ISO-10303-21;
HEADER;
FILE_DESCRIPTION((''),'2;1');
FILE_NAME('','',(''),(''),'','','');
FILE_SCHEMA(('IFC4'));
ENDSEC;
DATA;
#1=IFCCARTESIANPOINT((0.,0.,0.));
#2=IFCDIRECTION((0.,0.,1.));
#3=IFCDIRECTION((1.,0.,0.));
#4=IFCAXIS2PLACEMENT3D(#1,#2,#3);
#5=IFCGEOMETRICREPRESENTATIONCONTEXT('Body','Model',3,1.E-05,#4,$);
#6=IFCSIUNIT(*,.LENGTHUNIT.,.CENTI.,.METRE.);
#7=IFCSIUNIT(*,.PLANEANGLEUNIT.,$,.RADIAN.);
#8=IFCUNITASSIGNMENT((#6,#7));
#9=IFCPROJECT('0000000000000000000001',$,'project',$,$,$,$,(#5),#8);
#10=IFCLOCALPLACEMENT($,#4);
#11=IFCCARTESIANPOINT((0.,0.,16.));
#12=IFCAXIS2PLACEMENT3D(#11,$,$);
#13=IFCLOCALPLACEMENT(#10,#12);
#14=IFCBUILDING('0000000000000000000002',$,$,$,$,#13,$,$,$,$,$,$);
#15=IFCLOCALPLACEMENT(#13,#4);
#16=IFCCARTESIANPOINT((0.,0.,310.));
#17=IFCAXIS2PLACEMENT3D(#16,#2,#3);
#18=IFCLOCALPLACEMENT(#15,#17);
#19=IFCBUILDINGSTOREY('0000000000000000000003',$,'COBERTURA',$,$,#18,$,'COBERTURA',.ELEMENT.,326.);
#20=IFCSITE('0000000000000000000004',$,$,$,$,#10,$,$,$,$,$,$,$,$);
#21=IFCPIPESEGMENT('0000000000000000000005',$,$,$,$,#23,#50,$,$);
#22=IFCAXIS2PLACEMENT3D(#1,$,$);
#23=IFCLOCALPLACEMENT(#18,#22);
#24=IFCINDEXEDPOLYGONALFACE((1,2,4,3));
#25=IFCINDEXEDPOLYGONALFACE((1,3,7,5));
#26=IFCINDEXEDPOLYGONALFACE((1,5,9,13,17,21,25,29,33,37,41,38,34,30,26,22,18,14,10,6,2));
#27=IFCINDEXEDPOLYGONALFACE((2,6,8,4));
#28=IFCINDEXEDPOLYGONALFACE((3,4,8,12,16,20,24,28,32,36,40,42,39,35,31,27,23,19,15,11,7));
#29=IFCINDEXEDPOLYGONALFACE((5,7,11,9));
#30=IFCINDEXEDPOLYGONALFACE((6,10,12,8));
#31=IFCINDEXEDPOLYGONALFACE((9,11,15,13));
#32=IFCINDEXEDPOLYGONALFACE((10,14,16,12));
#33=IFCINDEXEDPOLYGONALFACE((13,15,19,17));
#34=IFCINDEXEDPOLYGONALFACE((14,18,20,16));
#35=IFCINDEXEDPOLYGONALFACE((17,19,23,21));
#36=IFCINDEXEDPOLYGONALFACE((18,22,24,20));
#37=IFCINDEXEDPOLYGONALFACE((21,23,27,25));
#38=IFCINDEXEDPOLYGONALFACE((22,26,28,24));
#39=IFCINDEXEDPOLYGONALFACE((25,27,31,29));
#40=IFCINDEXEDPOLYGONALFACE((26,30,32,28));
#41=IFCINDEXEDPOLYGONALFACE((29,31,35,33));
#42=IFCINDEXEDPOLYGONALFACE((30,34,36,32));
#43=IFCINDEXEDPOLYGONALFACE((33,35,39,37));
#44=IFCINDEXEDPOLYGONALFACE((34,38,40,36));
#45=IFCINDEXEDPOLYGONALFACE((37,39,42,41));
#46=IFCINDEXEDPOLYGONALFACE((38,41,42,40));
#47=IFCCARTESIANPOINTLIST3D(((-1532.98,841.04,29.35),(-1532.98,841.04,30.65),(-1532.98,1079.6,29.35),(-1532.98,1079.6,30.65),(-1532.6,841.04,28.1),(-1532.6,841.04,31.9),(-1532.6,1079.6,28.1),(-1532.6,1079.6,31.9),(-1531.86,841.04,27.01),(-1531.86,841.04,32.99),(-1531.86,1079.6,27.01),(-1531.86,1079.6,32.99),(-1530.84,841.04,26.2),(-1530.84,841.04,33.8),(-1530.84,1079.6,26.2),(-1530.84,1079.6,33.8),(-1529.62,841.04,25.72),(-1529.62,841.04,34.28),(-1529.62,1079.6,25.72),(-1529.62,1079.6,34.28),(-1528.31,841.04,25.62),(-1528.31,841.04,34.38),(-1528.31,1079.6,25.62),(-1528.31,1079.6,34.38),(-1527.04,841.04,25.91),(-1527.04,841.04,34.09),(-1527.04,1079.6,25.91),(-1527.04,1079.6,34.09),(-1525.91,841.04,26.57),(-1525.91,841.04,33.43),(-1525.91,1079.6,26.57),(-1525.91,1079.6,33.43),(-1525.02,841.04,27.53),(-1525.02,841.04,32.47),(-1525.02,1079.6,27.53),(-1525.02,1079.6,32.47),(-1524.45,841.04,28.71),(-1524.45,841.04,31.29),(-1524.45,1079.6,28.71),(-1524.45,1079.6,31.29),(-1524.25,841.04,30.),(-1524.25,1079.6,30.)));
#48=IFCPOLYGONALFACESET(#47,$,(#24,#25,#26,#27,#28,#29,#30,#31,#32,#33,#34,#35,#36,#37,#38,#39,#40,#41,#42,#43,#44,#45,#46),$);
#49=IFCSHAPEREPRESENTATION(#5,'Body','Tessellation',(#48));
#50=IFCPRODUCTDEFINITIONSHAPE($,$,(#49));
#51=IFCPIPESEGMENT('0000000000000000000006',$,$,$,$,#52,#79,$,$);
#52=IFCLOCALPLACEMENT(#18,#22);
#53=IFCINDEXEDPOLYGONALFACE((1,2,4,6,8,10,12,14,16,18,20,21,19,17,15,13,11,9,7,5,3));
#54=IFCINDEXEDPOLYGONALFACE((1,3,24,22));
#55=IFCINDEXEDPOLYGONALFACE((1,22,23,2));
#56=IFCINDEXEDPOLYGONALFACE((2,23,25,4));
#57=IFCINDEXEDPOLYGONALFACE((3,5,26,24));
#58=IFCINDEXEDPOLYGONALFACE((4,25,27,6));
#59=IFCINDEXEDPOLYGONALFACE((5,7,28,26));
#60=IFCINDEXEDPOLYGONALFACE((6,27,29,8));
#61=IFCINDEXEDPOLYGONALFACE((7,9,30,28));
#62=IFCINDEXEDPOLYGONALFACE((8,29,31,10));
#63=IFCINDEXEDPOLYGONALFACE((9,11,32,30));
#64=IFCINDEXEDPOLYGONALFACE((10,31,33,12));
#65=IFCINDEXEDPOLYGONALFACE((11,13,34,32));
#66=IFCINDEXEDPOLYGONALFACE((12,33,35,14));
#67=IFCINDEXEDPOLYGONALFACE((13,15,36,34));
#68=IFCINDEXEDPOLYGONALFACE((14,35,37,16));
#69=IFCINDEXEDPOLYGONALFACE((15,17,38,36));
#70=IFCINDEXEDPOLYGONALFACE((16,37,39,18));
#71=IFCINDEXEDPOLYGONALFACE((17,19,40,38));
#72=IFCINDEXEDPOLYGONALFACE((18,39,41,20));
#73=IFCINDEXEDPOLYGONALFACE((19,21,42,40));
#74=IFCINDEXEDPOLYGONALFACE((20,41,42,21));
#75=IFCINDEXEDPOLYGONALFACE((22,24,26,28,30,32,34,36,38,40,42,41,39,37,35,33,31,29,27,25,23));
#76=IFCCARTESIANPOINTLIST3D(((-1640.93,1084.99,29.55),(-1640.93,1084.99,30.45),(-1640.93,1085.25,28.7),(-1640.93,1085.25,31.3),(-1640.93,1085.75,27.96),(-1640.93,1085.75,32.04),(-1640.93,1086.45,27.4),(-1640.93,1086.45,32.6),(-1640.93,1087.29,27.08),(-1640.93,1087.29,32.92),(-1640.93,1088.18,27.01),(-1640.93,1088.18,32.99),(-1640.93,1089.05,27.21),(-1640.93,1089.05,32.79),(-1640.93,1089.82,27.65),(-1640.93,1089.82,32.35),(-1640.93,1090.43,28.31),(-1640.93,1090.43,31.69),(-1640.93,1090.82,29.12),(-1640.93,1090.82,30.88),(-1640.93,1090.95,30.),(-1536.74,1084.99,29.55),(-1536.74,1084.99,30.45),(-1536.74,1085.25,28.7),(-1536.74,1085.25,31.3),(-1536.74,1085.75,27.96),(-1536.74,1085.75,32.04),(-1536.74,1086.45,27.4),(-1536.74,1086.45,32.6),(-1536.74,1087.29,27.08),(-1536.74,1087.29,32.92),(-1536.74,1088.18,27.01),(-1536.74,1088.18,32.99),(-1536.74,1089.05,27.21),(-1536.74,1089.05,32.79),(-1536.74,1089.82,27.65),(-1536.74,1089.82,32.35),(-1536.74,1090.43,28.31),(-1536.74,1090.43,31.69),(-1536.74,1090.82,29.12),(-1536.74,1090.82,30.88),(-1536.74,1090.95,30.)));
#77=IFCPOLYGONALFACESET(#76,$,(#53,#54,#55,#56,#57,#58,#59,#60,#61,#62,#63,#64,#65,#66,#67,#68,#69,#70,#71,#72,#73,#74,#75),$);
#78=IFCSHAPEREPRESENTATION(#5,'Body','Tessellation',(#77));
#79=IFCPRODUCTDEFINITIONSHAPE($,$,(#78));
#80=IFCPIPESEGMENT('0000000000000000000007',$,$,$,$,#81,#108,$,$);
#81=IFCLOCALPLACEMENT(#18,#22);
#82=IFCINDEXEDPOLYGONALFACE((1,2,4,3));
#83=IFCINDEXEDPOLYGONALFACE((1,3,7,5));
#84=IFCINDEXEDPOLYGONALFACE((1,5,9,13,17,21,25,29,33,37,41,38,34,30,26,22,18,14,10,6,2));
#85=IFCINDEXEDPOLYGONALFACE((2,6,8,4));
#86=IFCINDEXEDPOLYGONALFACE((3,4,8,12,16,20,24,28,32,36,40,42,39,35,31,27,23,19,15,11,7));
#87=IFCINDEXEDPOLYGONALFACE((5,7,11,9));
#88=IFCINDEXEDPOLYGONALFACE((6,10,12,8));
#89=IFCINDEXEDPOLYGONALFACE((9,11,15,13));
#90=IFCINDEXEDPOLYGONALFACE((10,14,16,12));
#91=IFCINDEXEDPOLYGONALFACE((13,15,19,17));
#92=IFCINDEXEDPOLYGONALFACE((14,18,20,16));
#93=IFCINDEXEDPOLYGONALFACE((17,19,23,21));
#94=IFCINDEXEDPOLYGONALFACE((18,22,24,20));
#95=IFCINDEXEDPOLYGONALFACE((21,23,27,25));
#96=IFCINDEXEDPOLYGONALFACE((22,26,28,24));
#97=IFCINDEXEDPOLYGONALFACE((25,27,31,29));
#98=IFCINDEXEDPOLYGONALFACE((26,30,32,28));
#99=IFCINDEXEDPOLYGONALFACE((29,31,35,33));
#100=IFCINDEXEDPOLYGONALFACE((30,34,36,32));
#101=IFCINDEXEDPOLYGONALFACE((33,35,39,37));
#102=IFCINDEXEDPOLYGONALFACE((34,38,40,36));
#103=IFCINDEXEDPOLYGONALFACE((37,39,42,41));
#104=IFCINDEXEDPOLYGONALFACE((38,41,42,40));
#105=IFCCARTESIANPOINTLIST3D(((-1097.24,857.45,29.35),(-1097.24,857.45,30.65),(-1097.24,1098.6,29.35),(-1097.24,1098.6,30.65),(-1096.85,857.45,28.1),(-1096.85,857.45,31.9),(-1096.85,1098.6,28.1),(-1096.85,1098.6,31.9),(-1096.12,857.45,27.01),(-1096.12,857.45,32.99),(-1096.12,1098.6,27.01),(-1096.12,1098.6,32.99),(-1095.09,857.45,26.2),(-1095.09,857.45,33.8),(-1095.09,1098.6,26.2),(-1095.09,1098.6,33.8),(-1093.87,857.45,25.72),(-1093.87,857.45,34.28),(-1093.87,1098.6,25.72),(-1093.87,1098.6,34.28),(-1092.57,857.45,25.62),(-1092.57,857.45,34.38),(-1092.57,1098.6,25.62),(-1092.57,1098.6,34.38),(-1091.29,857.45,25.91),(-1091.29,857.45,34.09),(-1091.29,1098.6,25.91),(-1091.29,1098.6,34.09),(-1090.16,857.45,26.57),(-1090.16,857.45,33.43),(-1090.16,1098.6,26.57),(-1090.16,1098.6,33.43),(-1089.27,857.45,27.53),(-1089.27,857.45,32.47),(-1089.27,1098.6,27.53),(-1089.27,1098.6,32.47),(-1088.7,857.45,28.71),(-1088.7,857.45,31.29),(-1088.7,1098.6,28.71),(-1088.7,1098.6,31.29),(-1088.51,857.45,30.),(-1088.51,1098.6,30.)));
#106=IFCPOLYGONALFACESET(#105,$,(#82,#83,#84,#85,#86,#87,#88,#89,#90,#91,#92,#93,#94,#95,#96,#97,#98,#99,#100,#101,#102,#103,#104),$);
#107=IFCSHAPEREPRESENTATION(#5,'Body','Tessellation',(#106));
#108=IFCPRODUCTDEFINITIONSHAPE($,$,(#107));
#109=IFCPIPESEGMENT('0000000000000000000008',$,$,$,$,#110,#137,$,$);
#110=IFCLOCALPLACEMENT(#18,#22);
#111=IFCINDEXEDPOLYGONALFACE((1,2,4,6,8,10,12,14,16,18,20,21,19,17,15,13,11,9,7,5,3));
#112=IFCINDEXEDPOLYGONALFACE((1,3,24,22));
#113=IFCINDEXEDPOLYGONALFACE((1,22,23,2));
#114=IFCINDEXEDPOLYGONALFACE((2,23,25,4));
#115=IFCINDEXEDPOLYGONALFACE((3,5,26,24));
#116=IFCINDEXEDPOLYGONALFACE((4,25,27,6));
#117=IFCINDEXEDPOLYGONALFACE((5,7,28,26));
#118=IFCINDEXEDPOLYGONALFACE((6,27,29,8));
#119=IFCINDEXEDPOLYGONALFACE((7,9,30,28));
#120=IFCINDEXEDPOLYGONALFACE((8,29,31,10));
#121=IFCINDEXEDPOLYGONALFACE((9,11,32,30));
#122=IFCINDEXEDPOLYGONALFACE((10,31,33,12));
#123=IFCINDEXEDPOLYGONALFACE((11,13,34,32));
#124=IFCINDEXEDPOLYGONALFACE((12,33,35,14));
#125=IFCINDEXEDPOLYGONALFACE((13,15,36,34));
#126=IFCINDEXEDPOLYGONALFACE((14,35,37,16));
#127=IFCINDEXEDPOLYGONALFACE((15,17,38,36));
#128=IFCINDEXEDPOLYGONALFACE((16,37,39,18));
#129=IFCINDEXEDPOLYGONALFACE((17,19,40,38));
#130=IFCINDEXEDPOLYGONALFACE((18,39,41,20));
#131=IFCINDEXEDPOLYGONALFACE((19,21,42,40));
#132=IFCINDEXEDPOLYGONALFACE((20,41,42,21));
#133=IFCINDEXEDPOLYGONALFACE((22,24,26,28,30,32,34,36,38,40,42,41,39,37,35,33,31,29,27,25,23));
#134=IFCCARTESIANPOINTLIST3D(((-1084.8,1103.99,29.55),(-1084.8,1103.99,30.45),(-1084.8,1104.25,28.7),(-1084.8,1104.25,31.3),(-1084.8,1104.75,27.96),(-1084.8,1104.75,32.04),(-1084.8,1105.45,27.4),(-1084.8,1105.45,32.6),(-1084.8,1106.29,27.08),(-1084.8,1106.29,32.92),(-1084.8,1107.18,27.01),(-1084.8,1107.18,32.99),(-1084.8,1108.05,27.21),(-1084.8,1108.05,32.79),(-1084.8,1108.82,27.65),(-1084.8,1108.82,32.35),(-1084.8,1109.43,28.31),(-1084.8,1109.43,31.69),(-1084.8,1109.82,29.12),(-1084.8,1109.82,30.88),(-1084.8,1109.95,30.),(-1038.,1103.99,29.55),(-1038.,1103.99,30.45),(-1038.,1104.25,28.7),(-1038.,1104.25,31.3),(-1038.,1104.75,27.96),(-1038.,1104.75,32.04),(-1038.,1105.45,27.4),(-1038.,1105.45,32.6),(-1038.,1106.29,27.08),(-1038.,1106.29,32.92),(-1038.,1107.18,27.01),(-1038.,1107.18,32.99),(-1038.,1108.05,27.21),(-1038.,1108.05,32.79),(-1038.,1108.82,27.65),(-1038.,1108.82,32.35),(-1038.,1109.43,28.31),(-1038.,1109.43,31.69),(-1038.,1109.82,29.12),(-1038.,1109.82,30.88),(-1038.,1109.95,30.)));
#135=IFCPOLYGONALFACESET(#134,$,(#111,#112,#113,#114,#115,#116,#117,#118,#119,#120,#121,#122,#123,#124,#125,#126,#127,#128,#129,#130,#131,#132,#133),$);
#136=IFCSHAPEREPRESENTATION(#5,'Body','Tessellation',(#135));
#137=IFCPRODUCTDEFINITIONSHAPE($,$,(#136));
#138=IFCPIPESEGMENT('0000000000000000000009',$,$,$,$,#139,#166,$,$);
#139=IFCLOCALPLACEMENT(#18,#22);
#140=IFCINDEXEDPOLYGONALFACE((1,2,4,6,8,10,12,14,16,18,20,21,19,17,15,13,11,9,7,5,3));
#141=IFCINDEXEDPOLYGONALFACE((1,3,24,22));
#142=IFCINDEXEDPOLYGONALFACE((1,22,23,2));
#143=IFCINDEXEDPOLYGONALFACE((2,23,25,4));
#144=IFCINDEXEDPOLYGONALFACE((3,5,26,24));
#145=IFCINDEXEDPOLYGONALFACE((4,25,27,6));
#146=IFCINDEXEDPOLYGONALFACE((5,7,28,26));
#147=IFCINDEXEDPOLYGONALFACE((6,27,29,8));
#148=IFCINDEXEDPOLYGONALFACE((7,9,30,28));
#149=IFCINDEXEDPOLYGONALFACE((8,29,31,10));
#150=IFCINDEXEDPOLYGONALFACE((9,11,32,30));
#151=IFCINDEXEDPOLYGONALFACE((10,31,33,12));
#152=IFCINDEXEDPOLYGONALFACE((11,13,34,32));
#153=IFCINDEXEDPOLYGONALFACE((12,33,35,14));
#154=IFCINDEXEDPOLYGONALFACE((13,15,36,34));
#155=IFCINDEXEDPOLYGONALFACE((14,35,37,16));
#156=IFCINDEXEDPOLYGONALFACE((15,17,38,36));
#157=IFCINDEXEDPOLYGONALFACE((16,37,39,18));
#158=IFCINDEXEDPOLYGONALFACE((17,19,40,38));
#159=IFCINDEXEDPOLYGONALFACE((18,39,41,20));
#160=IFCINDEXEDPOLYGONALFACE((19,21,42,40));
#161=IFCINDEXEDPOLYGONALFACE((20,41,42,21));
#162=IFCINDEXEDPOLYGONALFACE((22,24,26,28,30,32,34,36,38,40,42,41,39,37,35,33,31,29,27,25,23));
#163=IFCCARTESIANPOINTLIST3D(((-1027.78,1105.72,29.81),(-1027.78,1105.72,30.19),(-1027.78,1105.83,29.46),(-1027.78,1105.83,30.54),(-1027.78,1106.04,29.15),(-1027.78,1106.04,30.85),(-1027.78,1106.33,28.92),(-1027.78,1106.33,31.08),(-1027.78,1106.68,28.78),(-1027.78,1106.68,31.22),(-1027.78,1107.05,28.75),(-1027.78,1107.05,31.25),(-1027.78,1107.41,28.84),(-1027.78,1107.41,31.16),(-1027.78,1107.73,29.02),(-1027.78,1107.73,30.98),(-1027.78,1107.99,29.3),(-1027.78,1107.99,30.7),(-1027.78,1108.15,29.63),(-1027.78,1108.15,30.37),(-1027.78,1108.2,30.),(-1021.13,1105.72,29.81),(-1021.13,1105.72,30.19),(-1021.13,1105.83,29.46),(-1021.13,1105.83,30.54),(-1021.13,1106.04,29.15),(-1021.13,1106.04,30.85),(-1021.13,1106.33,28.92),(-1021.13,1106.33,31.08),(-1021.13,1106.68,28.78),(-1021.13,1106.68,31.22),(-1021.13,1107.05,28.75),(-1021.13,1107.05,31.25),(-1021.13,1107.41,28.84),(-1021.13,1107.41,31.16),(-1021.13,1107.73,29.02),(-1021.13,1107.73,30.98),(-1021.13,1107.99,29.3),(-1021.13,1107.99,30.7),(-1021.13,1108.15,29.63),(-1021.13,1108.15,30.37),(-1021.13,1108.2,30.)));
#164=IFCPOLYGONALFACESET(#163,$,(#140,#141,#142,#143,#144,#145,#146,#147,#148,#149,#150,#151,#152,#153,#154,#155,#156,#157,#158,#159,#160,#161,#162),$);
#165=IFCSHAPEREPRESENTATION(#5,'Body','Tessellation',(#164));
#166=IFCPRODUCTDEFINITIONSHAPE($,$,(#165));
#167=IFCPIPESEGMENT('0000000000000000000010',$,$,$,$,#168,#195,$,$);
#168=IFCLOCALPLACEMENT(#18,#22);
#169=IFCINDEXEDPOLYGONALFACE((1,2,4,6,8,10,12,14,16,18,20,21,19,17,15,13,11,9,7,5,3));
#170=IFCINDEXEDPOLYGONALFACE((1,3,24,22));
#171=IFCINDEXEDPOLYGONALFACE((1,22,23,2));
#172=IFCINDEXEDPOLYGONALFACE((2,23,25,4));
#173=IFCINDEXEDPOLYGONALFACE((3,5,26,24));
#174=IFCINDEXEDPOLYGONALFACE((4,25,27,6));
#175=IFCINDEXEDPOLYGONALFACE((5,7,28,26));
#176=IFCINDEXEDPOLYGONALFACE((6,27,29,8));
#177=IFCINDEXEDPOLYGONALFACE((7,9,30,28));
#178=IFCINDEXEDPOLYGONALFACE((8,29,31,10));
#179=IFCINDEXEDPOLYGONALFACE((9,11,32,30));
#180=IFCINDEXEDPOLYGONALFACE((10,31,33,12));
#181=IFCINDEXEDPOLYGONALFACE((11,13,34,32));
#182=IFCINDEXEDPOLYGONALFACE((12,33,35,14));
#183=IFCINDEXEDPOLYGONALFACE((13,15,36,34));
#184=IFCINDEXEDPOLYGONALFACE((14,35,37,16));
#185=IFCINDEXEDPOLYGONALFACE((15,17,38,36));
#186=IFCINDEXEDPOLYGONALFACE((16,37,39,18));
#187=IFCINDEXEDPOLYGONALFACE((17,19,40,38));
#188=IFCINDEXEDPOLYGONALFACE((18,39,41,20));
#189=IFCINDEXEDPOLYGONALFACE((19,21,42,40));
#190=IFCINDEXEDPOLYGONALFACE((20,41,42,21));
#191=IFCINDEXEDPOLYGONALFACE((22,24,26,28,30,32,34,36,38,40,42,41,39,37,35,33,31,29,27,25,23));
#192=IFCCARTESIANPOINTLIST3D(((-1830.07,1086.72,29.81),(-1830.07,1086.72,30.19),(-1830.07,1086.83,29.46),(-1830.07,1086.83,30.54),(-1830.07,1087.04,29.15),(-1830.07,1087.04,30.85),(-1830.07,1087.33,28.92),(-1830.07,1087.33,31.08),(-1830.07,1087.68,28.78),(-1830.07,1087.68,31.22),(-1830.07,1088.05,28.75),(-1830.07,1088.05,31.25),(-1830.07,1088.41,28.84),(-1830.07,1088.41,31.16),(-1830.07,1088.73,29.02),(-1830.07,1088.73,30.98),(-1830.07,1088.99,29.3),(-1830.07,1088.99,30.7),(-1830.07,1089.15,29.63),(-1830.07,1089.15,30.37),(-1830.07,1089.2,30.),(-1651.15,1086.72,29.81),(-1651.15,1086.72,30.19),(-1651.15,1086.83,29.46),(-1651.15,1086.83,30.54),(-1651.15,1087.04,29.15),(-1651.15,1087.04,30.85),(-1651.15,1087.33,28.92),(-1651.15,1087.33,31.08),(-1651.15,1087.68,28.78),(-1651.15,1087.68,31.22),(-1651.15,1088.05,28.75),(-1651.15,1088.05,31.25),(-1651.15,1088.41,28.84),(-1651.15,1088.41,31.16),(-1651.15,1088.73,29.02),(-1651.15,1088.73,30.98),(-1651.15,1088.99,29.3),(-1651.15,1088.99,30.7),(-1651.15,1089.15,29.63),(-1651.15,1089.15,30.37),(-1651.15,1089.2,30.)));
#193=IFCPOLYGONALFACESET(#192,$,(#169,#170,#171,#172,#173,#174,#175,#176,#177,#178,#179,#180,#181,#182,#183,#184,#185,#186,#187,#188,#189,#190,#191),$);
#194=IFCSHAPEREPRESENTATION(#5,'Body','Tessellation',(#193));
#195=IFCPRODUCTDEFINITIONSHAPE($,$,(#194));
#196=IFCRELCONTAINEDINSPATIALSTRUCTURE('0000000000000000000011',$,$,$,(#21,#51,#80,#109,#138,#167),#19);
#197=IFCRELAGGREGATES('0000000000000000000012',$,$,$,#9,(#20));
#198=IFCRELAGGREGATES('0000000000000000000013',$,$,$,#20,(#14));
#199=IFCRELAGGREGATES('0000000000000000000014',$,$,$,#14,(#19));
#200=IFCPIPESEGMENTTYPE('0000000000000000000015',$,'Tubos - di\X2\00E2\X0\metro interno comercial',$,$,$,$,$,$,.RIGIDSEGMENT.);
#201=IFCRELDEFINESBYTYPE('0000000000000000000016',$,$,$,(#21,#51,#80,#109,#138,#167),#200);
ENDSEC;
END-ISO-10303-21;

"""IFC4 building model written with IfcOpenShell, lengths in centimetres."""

from ifc_helpers import new_model, si_unit, frame, origin_with_axes, origin_2d_with_axis, place, context, project, spatial, circle, extrude, type_object, element, save


model = new_model("IFC4")

# Units and contexts
model_context = context("Model", 3, precision=1e-05, world=origin_with_axes(), identifier="Body")
ifc_project = project(units=[si_unit("LENGTHUNIT", "METRE", prefix="CENTI"), si_unit("PLANEANGLEUNIT", "RADIAN")], contexts=[model_context])

# Site, building, storey
site_placement = place(None, origin_with_axes())
site = spatial("IfcSite", under=ifc_project, at=site_placement)
building_placement = place(site_placement, frame((0.0, 0.0, 16.0)))
building = spatial("IfcBuilding", under=site, at=building_placement)
placement = place(building_placement, origin_with_axes())
storey_placement = place(placement, frame((0.0, 0.0, 310.0), z_axis=(0.0, 0.0, 1.0), x_axis=(1.0, 0.0, 0.0)))
storey = spatial("IfcBuildingStorey", under=building, at=storey_placement, Name="COBERTURA", LongName="COBERTURA", CompositionType="ELEMENT", Elevation=326.0)

# Pipe segments
pipe_segment_type = type_object("IfcPipeSegmentType", Name="Tubos - diâmetro interno comercial", PredefinedType="RIGIDSEGMENT")
pipe_segment_1_placement = place(storey_placement, frame((-1528.64, 960.32, 34.39), z_axis=(0.0, 0.0, 1.0), x_axis=(1.0, 0.0, 0.0)))
element("IfcPipeSegment", 1, at=pipe_segment_1_placement, inside=storey, type_object=pipe_segment_type, context=model_context, shape_type="SolidModel", body=[
    extrude(circle(Radius=4.39, at=origin_2d_with_axis()), frame((0.0, 119.28, -4.39), z_axis=(0.0, -1.0, 0.0), x_axis=(1.0, 0.0, 0.0)), (0.0, 0.0, 1.0), 238.56),
])
pipe_segment_2_placement = place(storey_placement, frame((-1588.84, 1087.95, 33.0), z_axis=(0.0, 0.0, 1.0), x_axis=(1.0, 0.0, 0.0)))
element("IfcPipeSegment", 2, at=pipe_segment_2_placement, inside=storey, type_object=pipe_segment_type, context=model_context, shape_type="SolidModel", body=[
    extrude(circle(Radius=3.0, at=origin_2d_with_axis()), frame((52.1, 0.0, -3.0), z_axis=(-1.0, 0.0, 0.0), x_axis=(0.0, 1.0, 0.0)), (0.0, 0.0, 1.0), 104.19),
])
pipe_segment_3_placement = place(storey_placement, frame((-1092.9, 978.03, 34.39), z_axis=(0.0, 0.0, 1.0), x_axis=(1.0, 0.0, 0.0)))
element("IfcPipeSegment", 3, at=pipe_segment_3_placement, inside=storey, type_object=pipe_segment_type, context=model_context, shape_type="SolidModel", body=[
    extrude(circle(Radius=4.39, at=origin_2d_with_axis()), frame((0.0, 120.58, -4.39), z_axis=(0.0, -1.0, 0.0), x_axis=(1.0, 0.0, 0.0)), (0.0, 0.0, 1.0), 241.15),
])
pipe_segment_4_placement = place(storey_placement, frame((-1061.4, 1106.95, 33.0), z_axis=(0.0, 0.0, 1.0), x_axis=(1.0, 0.0, 0.0)))
element("IfcPipeSegment", 4, at=pipe_segment_4_placement, inside=storey, type_object=pipe_segment_type, context=model_context, shape_type="SolidModel", body=[
    extrude(circle(Radius=3.0, at=origin_2d_with_axis()), frame((-23.4, 0.0, -3.0), z_axis=(1.0, 0.0, 0.0), x_axis=(0.0, 1.0, 0.0)), (0.0, 0.0, 1.0), 46.8),
])
pipe_segment_5_placement = place(storey_placement, frame((-1024.45, 1106.95, 31.25), z_axis=(0.0, 0.0, 1.0), x_axis=(1.0, 0.0, 0.0)))
element("IfcPipeSegment", 5, at=pipe_segment_5_placement, inside=storey, type_object=pipe_segment_type, context=model_context, shape_type="SolidModel", body=[
    extrude(circle(Radius=1.25, at=origin_2d_with_axis()), frame((-3.32, 0.0, -1.25), z_axis=(1.0, 0.0, 0.0), x_axis=(0.0, 1.0, 0.0)), (0.0, 0.0, 1.0), 6.65),
])
pipe_segment_6_placement = place(storey_placement, frame((-1740.61, 1087.95, 31.25), z_axis=(0.0, 0.0, 1.0), x_axis=(1.0, 0.0, 0.0)))
element("IfcPipeSegment", 6, at=pipe_segment_6_placement, inside=storey, type_object=pipe_segment_type, context=model_context, shape_type="SolidModel", body=[
    extrude(circle(Radius=1.25, at=origin_2d_with_axis()), frame((89.46, 0.0, -1.25), z_axis=(-1.0, 0.0, 0.0), x_axis=(0.0, 1.0, 0.0)), (0.0, 0.0, 1.0), 178.92),
])

save(model, "model.ifc")
